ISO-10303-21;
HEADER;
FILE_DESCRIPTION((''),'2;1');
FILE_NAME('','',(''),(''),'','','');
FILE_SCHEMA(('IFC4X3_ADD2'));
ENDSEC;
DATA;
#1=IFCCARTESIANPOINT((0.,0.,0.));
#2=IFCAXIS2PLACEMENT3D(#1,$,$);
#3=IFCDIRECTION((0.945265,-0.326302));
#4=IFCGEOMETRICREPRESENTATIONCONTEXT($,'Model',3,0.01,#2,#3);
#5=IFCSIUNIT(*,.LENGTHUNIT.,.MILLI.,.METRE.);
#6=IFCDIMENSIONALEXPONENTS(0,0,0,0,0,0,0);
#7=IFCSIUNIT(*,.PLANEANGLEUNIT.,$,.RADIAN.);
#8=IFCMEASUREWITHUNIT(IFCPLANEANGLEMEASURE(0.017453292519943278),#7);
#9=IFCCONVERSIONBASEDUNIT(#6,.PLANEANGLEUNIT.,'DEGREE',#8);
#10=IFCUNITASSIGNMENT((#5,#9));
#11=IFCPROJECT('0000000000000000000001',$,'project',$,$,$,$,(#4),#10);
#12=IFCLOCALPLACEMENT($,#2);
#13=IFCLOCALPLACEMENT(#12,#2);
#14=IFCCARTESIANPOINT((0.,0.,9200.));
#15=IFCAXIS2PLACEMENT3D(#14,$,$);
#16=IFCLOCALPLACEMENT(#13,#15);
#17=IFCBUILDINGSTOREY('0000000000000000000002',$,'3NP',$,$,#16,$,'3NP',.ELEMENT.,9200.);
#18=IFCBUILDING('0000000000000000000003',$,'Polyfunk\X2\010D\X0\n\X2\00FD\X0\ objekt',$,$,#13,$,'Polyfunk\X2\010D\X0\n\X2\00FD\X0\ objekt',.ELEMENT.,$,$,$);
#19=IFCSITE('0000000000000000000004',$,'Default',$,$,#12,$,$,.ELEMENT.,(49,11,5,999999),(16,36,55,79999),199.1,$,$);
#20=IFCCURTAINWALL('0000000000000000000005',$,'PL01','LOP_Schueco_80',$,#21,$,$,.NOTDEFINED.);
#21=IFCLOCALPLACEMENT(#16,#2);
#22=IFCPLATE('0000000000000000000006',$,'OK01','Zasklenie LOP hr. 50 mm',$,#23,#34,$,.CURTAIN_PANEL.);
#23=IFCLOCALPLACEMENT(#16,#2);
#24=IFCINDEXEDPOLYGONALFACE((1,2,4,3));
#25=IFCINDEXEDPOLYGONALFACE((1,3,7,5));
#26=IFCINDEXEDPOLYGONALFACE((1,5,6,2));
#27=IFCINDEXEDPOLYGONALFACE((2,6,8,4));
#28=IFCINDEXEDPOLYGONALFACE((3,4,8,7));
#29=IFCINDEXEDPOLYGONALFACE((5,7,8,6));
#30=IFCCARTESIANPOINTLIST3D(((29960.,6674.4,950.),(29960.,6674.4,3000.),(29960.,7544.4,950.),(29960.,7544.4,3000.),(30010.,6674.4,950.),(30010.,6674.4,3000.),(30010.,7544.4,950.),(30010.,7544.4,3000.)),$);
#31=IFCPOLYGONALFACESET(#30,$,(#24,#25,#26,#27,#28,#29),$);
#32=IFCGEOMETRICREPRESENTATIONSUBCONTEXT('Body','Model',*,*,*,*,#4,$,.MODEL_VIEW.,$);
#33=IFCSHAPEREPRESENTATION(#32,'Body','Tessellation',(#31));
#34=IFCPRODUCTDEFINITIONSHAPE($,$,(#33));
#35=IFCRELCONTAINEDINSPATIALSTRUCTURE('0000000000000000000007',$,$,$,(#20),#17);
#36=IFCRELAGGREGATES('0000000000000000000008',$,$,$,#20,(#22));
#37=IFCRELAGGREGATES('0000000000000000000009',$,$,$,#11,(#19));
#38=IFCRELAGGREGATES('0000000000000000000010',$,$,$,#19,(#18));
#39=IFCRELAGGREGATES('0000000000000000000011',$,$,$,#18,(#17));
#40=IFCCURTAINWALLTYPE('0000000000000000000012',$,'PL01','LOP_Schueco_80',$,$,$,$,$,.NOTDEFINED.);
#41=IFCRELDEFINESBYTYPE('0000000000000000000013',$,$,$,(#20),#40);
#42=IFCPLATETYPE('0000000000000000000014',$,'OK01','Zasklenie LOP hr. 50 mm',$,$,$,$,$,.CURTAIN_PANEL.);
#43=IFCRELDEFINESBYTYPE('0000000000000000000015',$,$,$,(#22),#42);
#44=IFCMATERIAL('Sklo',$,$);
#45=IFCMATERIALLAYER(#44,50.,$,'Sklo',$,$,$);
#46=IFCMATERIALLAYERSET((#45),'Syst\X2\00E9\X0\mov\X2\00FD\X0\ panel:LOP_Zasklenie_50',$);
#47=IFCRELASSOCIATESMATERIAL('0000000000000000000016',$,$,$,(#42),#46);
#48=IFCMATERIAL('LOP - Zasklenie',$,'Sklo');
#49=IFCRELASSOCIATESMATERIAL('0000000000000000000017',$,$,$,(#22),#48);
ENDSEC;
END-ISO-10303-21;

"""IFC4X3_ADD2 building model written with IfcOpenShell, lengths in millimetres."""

from ifc_helpers import new_model, entity, si_unit, converted_unit, direction, frame, origin, origin_2d_with_axis, place, context, subcontext, project, spatial, rectangle, extrude, source, transform, mapped, material, layer, layer_set, type_object, element, aggregate, save


model = new_model("IFC4X3_ADD2")

# Units and contexts
model_context = context("Model", 3, precision=0.01, world=origin(), true_north=direction((0.945265, -0.326302)))
body_context = subcontext(model_context, "Body", "Model", "MODEL_VIEW")
ifc_project = project(units=[si_unit("LENGTHUNIT", "METRE", prefix="MILLI"), converted_unit("PLANEANGLEUNIT", "DEGREE", entity("IfcPlaneAngleMeasure", 0.017453292519943278), si_unit("PLANEANGLEUNIT", "RADIAN"), dimensions=[0, 0, 0, 0, 0, 0, 0])], contexts=[model_context])

# Site, building, storey
site_placement = place(None, origin())
site = spatial("IfcSite", under=ifc_project, at=site_placement, Name="Default", CompositionType="ELEMENT", RefLatitude=(49, 11, 5, 999999), RefLongitude=(16, 36, 55, 79999), RefElevation=199.1)
building_placement = place(site_placement, origin())
building = spatial("IfcBuilding", under=site, at=building_placement, Name="Polyfunkčný objekt", LongName="Polyfunkčný objekt", CompositionType="ELEMENT")
storey_placement = place(building_placement, frame((0.0, 0.0, 9200.0)))
storey = spatial("IfcBuildingStorey", under=building, at=storey_placement, Name="3NP", LongName="3NP", CompositionType="ELEMENT", Elevation=9200.0)

# Shared definitions
curtain_wall_type = type_object("IfcCurtainWallType", Name="PL01", Description="LOP_Schueco_80", PredefinedType="NOTDEFINED")

# Curtain wall, plate
curtain_wall_1_placement = place(storey_placement, frame((0.0, 0.0, -9200.0)))
curtain_wall_1 = element("IfcCurtainWall", 1, at=curtain_wall_1_placement, inside=storey, type_object=curtain_wall_type, Name="PL01", Description="LOP_Schueco_80", PredefinedType="NOTDEFINED")
ifc_material_1 = material(Name="LOP - Zasklenie", Category="Sklo")
ifc_material_2 = material(Name="Sklo")
ifc_layer_1 = layer(ifc_material_2, 50.0, Name="Sklo")
ifc_layer_set_1 = layer_set([ifc_layer_1], Name="Systémový panel:LOP_Zasklenie_50")
plate_type_1 = type_object("IfcPlateType", Name="OK01", Description="Zasklenie LOP hr. 50 mm", PredefinedType="CURTAIN_PANEL", material=ifc_layer_set_1)
shared_shape_1 = source(origin(), body_context, "Body", "SweptSolid", [
    extrude(rectangle(XDim=50.0, YDim=870.0, at=origin_2d_with_axis()), frame((0.0, -25.0, 0.0), z_axis=(0.0, 0.0, 1.0), x_axis=(0.0, 1.0, 0.0)), (0.0, 0.0, 1.0), 2050.0),
])
plate_1_placement = place(curtain_wall_1_placement, frame((30010.0, 7109.4, 10150.0), z_axis=(0.0, 0.0, 1.0), x_axis=(0.0, -1.0, 0.0)))
plate_1 = element("IfcPlate", 2, at=plate_1_placement, type_object=plate_type_1, material=ifc_material_1, Name="OK01", Description="Zasklenie LOP hr. 50 mm", PredefinedType="CURTAIN_PANEL", context=body_context, shape_type="MappedRepresentation", body=[
    mapped(shared_shape_1, transform((0.0, 0.0, 0.0), scale=1.0)),
])
aggregate(curtain_wall_1, [plate_1])

save(model, "model.ifc")
